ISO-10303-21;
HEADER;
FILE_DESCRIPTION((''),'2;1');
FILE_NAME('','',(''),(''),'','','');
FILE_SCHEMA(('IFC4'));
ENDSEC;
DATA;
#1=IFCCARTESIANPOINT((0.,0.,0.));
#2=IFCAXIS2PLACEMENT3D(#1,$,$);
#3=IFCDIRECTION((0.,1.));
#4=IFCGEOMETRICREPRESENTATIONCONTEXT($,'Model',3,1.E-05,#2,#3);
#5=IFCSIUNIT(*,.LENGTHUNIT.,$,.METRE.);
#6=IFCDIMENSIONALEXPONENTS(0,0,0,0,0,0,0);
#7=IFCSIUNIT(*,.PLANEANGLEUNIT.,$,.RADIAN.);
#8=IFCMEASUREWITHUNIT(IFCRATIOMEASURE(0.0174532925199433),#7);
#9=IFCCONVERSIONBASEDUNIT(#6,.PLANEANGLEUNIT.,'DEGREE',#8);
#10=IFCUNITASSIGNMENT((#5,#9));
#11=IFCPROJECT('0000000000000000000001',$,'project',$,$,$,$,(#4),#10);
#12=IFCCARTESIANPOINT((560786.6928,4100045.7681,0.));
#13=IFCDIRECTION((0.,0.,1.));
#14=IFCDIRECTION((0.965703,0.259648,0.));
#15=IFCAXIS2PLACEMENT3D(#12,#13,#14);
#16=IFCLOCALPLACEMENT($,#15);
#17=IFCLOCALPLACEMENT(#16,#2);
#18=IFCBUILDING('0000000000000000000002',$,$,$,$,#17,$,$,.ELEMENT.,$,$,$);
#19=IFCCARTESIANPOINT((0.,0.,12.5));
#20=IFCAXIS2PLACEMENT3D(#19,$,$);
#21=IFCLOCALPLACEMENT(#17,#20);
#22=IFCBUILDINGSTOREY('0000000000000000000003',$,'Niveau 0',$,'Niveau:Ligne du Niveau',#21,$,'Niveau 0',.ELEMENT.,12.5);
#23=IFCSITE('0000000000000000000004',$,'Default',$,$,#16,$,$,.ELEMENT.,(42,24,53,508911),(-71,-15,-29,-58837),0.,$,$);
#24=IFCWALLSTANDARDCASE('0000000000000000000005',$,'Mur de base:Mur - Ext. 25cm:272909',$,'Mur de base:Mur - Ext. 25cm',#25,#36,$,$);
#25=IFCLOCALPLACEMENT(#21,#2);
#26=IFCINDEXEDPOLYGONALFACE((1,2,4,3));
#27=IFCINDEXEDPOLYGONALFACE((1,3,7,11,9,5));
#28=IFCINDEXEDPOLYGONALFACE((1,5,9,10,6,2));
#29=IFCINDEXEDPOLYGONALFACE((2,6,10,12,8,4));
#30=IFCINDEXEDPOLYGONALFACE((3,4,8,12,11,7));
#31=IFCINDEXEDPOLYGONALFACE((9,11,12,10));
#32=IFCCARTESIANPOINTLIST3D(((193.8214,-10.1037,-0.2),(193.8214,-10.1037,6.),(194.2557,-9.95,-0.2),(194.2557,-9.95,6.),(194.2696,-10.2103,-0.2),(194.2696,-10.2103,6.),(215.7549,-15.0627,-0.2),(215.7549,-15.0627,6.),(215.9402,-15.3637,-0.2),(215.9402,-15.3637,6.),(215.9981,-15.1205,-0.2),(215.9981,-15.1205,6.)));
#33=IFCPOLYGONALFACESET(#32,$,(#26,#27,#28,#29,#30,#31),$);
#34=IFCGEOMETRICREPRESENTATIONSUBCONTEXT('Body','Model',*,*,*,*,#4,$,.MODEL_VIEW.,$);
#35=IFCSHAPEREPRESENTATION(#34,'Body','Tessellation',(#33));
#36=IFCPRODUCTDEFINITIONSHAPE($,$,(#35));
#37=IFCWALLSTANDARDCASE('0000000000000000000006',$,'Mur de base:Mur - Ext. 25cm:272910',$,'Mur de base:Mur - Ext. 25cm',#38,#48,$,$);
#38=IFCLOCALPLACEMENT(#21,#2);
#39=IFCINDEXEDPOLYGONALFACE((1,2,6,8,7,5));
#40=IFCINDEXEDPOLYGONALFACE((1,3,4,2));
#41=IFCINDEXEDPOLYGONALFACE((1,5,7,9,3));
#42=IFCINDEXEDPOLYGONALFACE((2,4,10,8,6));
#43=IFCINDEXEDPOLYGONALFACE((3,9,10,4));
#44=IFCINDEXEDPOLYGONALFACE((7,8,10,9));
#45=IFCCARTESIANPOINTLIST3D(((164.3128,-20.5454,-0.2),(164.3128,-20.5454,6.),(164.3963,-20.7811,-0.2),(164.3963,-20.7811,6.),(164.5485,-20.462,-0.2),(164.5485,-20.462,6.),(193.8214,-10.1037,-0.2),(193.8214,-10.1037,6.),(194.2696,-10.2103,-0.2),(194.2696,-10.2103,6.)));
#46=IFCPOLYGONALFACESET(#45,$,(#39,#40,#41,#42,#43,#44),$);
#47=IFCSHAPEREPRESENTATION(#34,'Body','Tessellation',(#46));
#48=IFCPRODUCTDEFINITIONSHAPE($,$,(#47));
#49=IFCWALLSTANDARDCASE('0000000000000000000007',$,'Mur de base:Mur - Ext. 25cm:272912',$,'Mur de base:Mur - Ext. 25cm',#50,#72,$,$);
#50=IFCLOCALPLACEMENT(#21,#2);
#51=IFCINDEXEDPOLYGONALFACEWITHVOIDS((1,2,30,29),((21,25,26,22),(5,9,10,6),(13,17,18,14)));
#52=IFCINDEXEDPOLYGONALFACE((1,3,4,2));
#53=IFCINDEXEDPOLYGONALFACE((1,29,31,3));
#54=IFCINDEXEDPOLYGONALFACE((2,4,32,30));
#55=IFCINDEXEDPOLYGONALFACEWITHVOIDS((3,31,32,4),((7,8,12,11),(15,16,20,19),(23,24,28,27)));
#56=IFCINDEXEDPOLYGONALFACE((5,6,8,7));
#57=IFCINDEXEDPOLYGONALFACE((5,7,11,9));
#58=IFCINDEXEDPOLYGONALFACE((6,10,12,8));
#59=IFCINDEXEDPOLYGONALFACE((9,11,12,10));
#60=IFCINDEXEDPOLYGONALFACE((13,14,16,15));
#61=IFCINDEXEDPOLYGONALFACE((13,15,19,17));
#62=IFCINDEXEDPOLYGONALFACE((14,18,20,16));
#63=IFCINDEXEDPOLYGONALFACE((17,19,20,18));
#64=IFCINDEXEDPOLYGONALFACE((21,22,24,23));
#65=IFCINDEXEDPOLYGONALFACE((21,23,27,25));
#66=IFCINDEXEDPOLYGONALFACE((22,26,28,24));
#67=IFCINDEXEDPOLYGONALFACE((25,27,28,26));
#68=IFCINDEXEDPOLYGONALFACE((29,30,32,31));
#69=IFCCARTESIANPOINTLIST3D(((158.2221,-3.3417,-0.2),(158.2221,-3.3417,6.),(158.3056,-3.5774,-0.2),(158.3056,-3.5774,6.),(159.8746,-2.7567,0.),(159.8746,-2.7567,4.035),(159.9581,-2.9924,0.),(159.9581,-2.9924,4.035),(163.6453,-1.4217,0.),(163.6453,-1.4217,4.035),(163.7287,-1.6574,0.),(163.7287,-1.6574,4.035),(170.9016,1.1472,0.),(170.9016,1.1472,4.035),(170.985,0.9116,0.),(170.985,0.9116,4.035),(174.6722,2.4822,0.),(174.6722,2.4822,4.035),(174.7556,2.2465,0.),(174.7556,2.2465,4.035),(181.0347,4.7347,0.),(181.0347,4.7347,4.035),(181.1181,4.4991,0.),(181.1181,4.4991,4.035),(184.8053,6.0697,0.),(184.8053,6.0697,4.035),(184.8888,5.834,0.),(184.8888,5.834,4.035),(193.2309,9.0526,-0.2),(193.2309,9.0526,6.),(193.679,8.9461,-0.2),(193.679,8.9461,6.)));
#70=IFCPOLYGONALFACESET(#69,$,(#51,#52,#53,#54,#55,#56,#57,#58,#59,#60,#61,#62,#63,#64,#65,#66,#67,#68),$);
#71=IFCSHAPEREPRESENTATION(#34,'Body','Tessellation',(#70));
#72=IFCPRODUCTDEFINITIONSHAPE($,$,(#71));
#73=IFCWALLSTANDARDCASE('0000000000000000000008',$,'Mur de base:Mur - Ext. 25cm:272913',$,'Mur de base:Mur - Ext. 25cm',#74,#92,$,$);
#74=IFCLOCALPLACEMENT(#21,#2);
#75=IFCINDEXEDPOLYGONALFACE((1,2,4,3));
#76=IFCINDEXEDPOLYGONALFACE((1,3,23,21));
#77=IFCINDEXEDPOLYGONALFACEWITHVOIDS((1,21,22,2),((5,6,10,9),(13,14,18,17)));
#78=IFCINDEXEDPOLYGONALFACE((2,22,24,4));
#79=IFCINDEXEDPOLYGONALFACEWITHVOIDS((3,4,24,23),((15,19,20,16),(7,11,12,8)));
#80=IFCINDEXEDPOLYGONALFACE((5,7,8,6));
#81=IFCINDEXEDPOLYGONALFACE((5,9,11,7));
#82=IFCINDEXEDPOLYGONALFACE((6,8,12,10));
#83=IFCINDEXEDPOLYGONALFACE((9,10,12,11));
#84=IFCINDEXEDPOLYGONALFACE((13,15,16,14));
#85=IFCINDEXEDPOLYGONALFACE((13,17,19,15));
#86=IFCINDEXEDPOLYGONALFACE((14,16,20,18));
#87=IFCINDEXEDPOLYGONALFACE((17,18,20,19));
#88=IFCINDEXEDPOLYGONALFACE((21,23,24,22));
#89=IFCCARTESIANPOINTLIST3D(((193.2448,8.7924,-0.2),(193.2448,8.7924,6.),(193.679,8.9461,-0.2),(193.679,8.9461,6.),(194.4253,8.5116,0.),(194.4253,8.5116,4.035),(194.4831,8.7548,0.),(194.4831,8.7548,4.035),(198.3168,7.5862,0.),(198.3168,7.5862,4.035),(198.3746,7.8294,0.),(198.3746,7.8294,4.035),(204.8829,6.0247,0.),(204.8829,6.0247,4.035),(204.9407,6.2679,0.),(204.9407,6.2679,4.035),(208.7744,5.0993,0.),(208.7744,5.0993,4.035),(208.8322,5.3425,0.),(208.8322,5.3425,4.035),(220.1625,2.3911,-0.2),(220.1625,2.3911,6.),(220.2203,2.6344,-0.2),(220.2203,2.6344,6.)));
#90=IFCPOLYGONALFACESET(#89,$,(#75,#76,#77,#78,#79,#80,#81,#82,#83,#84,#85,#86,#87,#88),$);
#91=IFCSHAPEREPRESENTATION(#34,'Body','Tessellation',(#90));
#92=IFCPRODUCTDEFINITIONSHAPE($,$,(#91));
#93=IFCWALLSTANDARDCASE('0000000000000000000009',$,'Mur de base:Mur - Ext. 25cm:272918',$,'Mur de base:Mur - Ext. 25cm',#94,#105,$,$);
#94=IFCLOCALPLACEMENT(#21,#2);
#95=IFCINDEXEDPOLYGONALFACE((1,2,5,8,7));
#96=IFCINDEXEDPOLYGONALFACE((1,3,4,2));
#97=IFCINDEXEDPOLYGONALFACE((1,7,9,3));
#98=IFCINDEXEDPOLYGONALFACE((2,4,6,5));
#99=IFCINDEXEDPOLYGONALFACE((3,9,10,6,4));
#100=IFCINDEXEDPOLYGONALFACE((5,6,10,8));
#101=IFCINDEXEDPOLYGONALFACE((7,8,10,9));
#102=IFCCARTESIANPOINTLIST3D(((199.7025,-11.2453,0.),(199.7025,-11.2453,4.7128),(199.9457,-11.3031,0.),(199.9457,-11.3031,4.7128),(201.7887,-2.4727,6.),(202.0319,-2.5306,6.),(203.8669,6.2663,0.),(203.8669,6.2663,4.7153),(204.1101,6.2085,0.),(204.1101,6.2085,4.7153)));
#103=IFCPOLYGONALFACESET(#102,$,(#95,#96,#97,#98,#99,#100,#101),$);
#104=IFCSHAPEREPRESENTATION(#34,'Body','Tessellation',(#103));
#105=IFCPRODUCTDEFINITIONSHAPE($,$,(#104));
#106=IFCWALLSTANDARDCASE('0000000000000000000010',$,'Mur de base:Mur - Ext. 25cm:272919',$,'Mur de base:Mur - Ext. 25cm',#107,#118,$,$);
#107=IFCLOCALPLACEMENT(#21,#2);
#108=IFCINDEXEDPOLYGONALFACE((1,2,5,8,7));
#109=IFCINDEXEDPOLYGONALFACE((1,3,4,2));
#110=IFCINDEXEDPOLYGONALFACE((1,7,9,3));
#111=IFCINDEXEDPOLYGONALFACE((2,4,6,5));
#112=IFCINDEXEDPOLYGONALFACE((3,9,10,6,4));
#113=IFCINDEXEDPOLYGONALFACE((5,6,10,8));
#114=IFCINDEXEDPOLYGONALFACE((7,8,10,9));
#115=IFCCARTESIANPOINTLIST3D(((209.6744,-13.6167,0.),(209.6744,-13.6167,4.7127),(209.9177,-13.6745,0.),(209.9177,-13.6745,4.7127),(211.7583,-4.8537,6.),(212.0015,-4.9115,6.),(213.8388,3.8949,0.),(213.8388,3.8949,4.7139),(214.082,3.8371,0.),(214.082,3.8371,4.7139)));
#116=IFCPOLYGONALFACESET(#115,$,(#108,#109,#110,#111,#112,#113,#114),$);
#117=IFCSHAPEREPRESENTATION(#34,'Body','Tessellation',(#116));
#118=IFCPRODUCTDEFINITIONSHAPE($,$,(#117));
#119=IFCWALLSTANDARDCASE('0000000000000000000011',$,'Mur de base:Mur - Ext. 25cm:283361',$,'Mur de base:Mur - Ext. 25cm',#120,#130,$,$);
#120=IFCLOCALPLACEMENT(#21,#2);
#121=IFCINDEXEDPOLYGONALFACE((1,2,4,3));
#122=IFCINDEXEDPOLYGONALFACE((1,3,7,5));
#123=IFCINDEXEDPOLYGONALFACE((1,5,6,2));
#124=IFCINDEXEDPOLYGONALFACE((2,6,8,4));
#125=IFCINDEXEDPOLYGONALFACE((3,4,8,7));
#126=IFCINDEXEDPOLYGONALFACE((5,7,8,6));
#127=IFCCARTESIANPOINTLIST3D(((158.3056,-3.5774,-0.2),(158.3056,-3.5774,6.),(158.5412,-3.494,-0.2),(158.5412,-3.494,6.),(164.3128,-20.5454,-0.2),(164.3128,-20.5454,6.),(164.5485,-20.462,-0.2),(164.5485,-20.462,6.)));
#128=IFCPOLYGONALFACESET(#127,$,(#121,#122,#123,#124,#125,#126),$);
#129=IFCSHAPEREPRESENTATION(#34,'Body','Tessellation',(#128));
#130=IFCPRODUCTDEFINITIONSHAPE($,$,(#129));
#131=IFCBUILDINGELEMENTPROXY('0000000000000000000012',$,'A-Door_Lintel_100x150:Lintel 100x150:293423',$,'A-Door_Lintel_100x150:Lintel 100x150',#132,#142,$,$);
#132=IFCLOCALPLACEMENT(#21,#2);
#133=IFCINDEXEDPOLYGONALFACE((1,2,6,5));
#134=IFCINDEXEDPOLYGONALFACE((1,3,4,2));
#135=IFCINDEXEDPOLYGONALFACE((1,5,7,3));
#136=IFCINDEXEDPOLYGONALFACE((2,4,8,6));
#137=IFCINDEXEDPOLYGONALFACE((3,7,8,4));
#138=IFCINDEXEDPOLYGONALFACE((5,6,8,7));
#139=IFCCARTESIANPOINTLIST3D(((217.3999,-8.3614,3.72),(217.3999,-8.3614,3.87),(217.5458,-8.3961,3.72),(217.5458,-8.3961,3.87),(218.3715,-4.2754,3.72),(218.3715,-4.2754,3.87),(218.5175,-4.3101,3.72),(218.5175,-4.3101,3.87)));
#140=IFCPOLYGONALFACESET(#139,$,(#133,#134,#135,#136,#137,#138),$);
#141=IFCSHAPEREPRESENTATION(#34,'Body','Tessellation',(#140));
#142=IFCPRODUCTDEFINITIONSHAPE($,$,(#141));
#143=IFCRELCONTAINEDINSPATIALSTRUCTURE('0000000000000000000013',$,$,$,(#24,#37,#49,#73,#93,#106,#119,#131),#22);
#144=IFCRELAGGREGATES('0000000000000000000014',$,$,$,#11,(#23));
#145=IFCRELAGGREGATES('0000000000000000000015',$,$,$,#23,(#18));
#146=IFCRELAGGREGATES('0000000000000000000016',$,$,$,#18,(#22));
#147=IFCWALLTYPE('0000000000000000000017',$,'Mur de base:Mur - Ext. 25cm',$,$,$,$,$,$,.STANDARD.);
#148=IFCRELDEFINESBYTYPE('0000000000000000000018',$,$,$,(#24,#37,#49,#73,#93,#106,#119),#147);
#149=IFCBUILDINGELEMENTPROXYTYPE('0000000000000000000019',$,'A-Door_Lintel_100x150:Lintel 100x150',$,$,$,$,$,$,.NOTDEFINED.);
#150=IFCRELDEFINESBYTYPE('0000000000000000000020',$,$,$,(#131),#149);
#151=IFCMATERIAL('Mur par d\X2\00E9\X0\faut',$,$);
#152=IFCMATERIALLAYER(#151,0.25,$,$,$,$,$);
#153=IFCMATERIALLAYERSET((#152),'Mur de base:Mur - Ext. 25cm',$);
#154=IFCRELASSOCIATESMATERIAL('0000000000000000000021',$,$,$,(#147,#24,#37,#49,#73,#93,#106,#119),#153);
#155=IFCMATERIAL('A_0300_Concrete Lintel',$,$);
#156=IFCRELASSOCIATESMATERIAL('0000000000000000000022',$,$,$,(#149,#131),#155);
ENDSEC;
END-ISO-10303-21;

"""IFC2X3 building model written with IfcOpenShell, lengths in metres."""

from ifc_helpers import new_model, entity, si_unit, converted_unit, direction, frame, frame_2d, origin, origin_2d_with_axis, place, context, subcontext, project, spatial, polyline, rectangle, outline, extrude, clip, halfspace, source, transform, mapped, material, layer, layer_set, layer_usage, type_object, type_shapes, element, save


model = new_model("IFC2X3")

# Units and contexts
model_context = context("Model", 3, precision=1e-05, world=origin(), true_north=direction((0.0, 1.0)))
body_context = subcontext(model_context, "Body", "Model", "MODEL_VIEW")
ifc_project = project(units=[si_unit("LENGTHUNIT", "METRE"), converted_unit("PLANEANGLEUNIT", "DEGREE", entity("IfcRatioMeasure", 0.0174532925199433), si_unit("PLANEANGLEUNIT", "RADIAN"), dimensions=[0, 0, 0, 0, 0, 0, 0])], contexts=[model_context])

# Site, building, storey
site_placement = place(None, frame((560786.6928, 4100045.7681, 0.0), z_axis=(0.0, 0.0, 1.0), x_axis=(0.965703, 0.259648, 0.0)))
site = spatial("IfcSite", under=ifc_project, at=site_placement, Name="Default", CompositionType="ELEMENT", RefLatitude=(42, 24, 53, 508911), RefLongitude=(-71, -15, -29, -58837), RefElevation=0.0)
building_placement = place(site_placement, origin())
building = spatial("IfcBuilding", under=site, at=building_placement, CompositionType="ELEMENT")
storey_placement = place(building_placement, frame((0.0, 0.0, 12.5)))
storey = spatial("IfcBuildingStorey", under=building, at=storey_placement, Name="Niveau 0", ObjectType="Niveau:Ligne du Niveau", LongName="Niveau 0", CompositionType="ELEMENT", Elevation=12.5)

# Walls
ifc_material_1 = material(Name="Mur par défaut")
ifc_layer_1 = layer(ifc_material_1, 0.25)
ifc_layer_set_1 = layer_set([ifc_layer_1], Name="Mur de base:Mur - Ext. 25cm")
ifc_layer_usage_1 = layer_usage(ifc_layer_set_1, "AXIS2", "NEGATIVE", 0.125)
wall_type = type_object("IfcWallType", Name="Mur de base:Mur - Ext. 25cm", PredefinedType="STANDARD", material=ifc_layer_set_1)
wall_1_placement = place(storey_placement, frame((215.9692, -15.2421, -0.2), z_axis=(0.0, 0.0, 1.0), x_axis=(-0.97287, 0.231354, 0.0)))
element("IfcWallStandardCase", 1, at=wall_1_placement, inside=storey, type_object=wall_type, material=ifc_layer_usage_1, Name="Mur de base:Mur - Ext. 25cm:272909", ObjectType="Mur de base:Mur - Ext. 25cm", context=body_context, shape_type="SweptSolid", body=[
    extrude(outline(polyline([(22.3487, -0.125), (22.7357, 0.125), (22.275, 0.125), (0.0, 0.125), (0.0, -0.125), (0.25, -0.125), (22.3487, -0.125)])), origin(), (0.0, 0.0, 1.0), 6.2),
])
ifc_layer_usage_2 = layer_usage(ifc_layer_set_1, "AXIS2", "NEGATIVE", 0.125)
wall_2_placement = place(storey_placement, frame((194.2279, -10.0924, -0.2), z_axis=(0.0, 0.0, 1.0), x_axis=(-0.94272, -0.333584, 0.0)))
element("IfcWallStandardCase", 2, at=wall_2_placement, inside=storey, type_object=wall_type, material=ifc_layer_usage_2, Name="Mur de base:Mur - Ext. 25cm:272910", ObjectType="Mur de base:Mur - Ext. 25cm", context=body_context, shape_type="SweptSolid", body=[
    extrude(outline(polyline([(31.6885, -0.125), (31.6884, 0.125), (0.0, 0.125), (0.387, -0.125), (31.4385, -0.125), (31.6885, -0.125)])), origin(), (0.0, 0.0, 1.0), 6.2),
])

# Walls, openings
ifc_layer_usage_3 = layer_usage(ifc_layer_set_1, "AXIS2", "NEGATIVE", 0.125)
wall_3_placement = place(storey_placement, frame((158.2638, -3.4596, -0.2), z_axis=(0.0, 0.0, 1.0), x_axis=(0.942666, 0.333738, 0.0)))
wall_3 = element("IfcWallStandardCase", 3, at=wall_3_placement, inside=storey, type_object=wall_type, material=ifc_layer_usage_3, Name="Mur de base:Mur - Ext. 25cm:272912", ObjectType="Mur de base:Mur - Ext. 25cm", context=body_context, shape_type="SweptSolid", body=[
    extrude(outline(polyline([(37.5249, -0.125), (37.138, 0.125), (0.0, 0.125), (0.0, -0.125), (0.25, -0.125), (37.0643, -0.125), (37.5249, -0.125)])), origin(), (0.0, 0.0, 1.0), 6.2),
])
opening_1_placement = place(wall_3_placement, frame((24.2, -0.125, 0.2)))
element("IfcOpeningElement", 4, at=opening_1_placement, cuts=wall_3, ObjectType="Opening", context=body_context, shape_type="SweptSolid", body=[
    extrude(rectangle(XDim=4.035, YDim=4.0, at=frame_2d((2.0175, 2.0), x_axis=(1.0, 0.0))), frame((0.0, 0.0, 0.0), z_axis=(0.0, 1.0, 0.0), x_axis=(0.0, 0.0, 1.0)), (0.0, 0.0, 1.0), 0.25),
])
opening_2_placement = place(wall_3_placement, frame((13.4506, -0.125, 0.2)))
element("IfcOpeningElement", 5, at=opening_2_placement, cuts=wall_3, ObjectType="Opening", context=body_context, shape_type="SweptSolid", body=[
    extrude(rectangle(XDim=4.035, YDim=4.0, at=frame_2d((2.0175, 2.0), x_axis=(1.0, 0.0))), frame((0.0, 0.0, 0.0), z_axis=(0.0, 1.0, 0.0), x_axis=(0.0, 0.0, 1.0)), (0.0, 0.0, 1.0), 0.25),
])
opening_3_placement = place(wall_3_placement, frame((1.753, -0.125, 0.2)))
element("IfcOpeningElement", 6, at=opening_3_placement, cuts=wall_3, ObjectType="Opening", context=body_context, shape_type="SweptSolid", body=[
    extrude(rectangle(XDim=4.035, YDim=4.0, at=frame_2d((2.0175, 2.0), x_axis=(1.0, 0.0))), frame((0.0, 0.0, 0.0), z_axis=(0.0, 1.0, 0.0), x_axis=(0.0, 0.0, 1.0)), (0.0, 0.0, 1.0), 0.25),
])
ifc_layer_usage_4 = layer_usage(ifc_layer_set_1, "AXIS2", "NEGATIVE", 0.125)
wall_4_placement = place(storey_placement, frame((193.2737, 8.914, -0.2), z_axis=(0.0, 0.0, 1.0), x_axis=(0.972869, -0.231355, 0.0)))
wall_4 = element("IfcWallStandardCase", 7, at=wall_4_placement, inside=storey, type_object=wall_type, material=ifc_layer_usage_4, Name="Mur de base:Mur - Ext. 25cm:272913", ObjectType="Mur de base:Mur - Ext. 25cm", context=body_context, shape_type="SweptSolid", body=[
    extrude(outline(polyline([(27.6683, -0.125), (27.6683, 0.125), (0.3868, 0.125), (0.0, -0.125), (27.4183, -0.125), (27.6683, -0.125)])), origin(), (0.0, 0.0, 1.0), 6.2),
])
opening_4_placement = place(wall_4_placement, frame((11.9627, -0.125, 0.2)))
element("IfcOpeningElement", 8, at=opening_4_placement, cuts=wall_4, ObjectType="Opening", context=body_context, shape_type="SweptSolid", body=[
    extrude(rectangle(XDim=4.035, YDim=4.0, at=frame_2d((2.0175, 2.0), x_axis=(1.0, 0.0))), frame((0.0, 0.0, 0.0), z_axis=(0.0, 1.0, 0.0), x_axis=(0.0, 0.0, 1.0)), (0.0, 0.0, 1.0), 0.25),
])
opening_5_placement = place(wall_4_placement, frame((1.2134, -0.125, 0.2)))
element("IfcOpeningElement", 9, at=opening_5_placement, cuts=wall_4, ObjectType="Opening", context=body_context, shape_type="SweptSolid", body=[
    extrude(rectangle(XDim=4.035, YDim=4.0, at=frame_2d((2.0175, 2.0), x_axis=(1.0, 0.0))), frame((0.0, 0.0, 0.0), z_axis=(0.0, 1.0, 0.0), x_axis=(0.0, 0.0, 1.0)), (0.0, 0.0, 1.0), 0.25),
])

# Walls
ifc_layer_usage_5 = layer_usage(ifc_layer_set_1, "AXIS2", "POSITIVE", -0.125)
wall_5_placement = place(storey_placement, frame((203.9885, 6.2374, 0.0), z_axis=(0.0, 0.0, 1.0), x_axis=(-0.231354, -0.97287, 0.0)))
element("IfcWallStandardCase", 10, at=wall_5_placement, inside=storey, type_object=wall_type, material=ifc_layer_usage_5, Name="Mur de base:Mur - Ext. 25cm:272918", ObjectType="Mur de base:Mur - Ext. 25cm", context=body_context, shape_type="Clipping", body=[
    clip(clip(extrude(rectangle(XDim=18.0, YDim=0.25, at=frame_2d((9.0, 0.0), x_axis=(-1.0, 0.0))), origin(), (0.0, 0.0, 1.0), 6.0), halfspace(frame((8.9828, -0.125, 6.0), z_axis=(0.141317, 0.0, 0.989964), x_axis=(0.0, 1.0, 0.0)), False)), halfspace(frame((0.0, -0.125, 4.7153), z_axis=(-0.141574, 0.0, 0.989928), x_axis=(0.0, 1.0, 0.0)), False)),
])
ifc_layer_usage_6 = layer_usage(ifc_layer_set_1, "AXIS2", "POSITIVE", -0.125)
wall_6_placement = place(storey_placement, frame((213.9604, 3.866, 0.0), z_axis=(0.0, 0.0, 1.0), x_axis=(-0.231354, -0.97287, 0.0)))
element("IfcWallStandardCase", 11, at=wall_6_placement, inside=storey, type_object=wall_type, material=ifc_layer_usage_6, Name="Mur de base:Mur - Ext. 25cm:272919", ObjectType="Mur de base:Mur - Ext. 25cm", context=body_context, shape_type="Clipping", body=[
    clip(clip(extrude(rectangle(XDim=18.0, YDim=0.25, at=frame_2d((9.0, 0.0), x_axis=(-1.0, 0.0))), origin(), (0.0, 0.0, 1.0), 6.0), halfspace(frame((8.9926, -0.125, 6.0), z_axis=(0.141475, 0.0, 0.989942), x_axis=(0.0, 1.0, 0.0)), False)), halfspace(frame((0.0, -0.125, 4.7139), z_axis=(-0.141574, 0.0, 0.989928), x_axis=(0.0, 1.0, 0.0)), False)),
])
ifc_layer_usage_7 = layer_usage(ifc_layer_set_1, "AXIS2", "POSITIVE", -0.125)
wall_7_placement = place(storey_placement, frame((158.4234, -3.5357, -0.2), z_axis=(0.0, 0.0, 1.0), x_axis=(0.333738, -0.942666, 0.0)))
element("IfcWallStandardCase", 12, at=wall_7_placement, inside=storey, type_object=wall_type, material=ifc_layer_usage_7, Name="Mur de base:Mur - Ext. 25cm:283361", ObjectType="Mur de base:Mur - Ext. 25cm", context=body_context, shape_type="SweptSolid", body=[
    extrude(outline(polyline([(18.0, -0.125), (18.0, 0.125), (0.0, 0.125), (0.0, -0.125), (18.0, -0.125)])), origin(), (0.0, 0.0, 1.0), 6.2),
])

# Building element proxy
ifc_material_2 = material(Name="A_0300_Concrete Lintel")
building_element_proxy_type = type_object("IfcBuildingElementProxyType", Name="A-Door_Lintel_100x150:Lintel 100x150", PredefinedType="NOTDEFINED", material=ifc_material_2)
shared_shape = source(origin(), body_context, "Body", "SweptSolid", [
    extrude(rectangle(XDim=4.2, YDim=0.15, at=origin_2d_with_axis()), frame((0.0, 0.0, 0.0), z_axis=(0.0, 0.0, 1.0), x_axis=(-1.0, 0.0, 0.0)), (0.0, 0.0, 1.0), 0.15),
])
type_shapes(building_element_proxy_type, [shared_shape])
proxy_placement = place(storey_placement, frame((217.9587, -6.3358, 3.72), z_axis=(0.0, 0.0, 1.0), x_axis=(-0.231354, -0.97287, 0.0)))
element("IfcBuildingElementProxy", 13, at=proxy_placement, inside=storey, type_object=building_element_proxy_type, material=ifc_material_2, Name="A-Door_Lintel_100x150:Lintel 100x150:293423", ObjectType="A-Door_Lintel_100x150:Lintel 100x150", context=body_context, shape_type="MappedRepresentation", body=[
    mapped(shared_shape, transform((0.0, 0.0, 0.0), scale=1.0)),
])

save(model, "model.ifc")
